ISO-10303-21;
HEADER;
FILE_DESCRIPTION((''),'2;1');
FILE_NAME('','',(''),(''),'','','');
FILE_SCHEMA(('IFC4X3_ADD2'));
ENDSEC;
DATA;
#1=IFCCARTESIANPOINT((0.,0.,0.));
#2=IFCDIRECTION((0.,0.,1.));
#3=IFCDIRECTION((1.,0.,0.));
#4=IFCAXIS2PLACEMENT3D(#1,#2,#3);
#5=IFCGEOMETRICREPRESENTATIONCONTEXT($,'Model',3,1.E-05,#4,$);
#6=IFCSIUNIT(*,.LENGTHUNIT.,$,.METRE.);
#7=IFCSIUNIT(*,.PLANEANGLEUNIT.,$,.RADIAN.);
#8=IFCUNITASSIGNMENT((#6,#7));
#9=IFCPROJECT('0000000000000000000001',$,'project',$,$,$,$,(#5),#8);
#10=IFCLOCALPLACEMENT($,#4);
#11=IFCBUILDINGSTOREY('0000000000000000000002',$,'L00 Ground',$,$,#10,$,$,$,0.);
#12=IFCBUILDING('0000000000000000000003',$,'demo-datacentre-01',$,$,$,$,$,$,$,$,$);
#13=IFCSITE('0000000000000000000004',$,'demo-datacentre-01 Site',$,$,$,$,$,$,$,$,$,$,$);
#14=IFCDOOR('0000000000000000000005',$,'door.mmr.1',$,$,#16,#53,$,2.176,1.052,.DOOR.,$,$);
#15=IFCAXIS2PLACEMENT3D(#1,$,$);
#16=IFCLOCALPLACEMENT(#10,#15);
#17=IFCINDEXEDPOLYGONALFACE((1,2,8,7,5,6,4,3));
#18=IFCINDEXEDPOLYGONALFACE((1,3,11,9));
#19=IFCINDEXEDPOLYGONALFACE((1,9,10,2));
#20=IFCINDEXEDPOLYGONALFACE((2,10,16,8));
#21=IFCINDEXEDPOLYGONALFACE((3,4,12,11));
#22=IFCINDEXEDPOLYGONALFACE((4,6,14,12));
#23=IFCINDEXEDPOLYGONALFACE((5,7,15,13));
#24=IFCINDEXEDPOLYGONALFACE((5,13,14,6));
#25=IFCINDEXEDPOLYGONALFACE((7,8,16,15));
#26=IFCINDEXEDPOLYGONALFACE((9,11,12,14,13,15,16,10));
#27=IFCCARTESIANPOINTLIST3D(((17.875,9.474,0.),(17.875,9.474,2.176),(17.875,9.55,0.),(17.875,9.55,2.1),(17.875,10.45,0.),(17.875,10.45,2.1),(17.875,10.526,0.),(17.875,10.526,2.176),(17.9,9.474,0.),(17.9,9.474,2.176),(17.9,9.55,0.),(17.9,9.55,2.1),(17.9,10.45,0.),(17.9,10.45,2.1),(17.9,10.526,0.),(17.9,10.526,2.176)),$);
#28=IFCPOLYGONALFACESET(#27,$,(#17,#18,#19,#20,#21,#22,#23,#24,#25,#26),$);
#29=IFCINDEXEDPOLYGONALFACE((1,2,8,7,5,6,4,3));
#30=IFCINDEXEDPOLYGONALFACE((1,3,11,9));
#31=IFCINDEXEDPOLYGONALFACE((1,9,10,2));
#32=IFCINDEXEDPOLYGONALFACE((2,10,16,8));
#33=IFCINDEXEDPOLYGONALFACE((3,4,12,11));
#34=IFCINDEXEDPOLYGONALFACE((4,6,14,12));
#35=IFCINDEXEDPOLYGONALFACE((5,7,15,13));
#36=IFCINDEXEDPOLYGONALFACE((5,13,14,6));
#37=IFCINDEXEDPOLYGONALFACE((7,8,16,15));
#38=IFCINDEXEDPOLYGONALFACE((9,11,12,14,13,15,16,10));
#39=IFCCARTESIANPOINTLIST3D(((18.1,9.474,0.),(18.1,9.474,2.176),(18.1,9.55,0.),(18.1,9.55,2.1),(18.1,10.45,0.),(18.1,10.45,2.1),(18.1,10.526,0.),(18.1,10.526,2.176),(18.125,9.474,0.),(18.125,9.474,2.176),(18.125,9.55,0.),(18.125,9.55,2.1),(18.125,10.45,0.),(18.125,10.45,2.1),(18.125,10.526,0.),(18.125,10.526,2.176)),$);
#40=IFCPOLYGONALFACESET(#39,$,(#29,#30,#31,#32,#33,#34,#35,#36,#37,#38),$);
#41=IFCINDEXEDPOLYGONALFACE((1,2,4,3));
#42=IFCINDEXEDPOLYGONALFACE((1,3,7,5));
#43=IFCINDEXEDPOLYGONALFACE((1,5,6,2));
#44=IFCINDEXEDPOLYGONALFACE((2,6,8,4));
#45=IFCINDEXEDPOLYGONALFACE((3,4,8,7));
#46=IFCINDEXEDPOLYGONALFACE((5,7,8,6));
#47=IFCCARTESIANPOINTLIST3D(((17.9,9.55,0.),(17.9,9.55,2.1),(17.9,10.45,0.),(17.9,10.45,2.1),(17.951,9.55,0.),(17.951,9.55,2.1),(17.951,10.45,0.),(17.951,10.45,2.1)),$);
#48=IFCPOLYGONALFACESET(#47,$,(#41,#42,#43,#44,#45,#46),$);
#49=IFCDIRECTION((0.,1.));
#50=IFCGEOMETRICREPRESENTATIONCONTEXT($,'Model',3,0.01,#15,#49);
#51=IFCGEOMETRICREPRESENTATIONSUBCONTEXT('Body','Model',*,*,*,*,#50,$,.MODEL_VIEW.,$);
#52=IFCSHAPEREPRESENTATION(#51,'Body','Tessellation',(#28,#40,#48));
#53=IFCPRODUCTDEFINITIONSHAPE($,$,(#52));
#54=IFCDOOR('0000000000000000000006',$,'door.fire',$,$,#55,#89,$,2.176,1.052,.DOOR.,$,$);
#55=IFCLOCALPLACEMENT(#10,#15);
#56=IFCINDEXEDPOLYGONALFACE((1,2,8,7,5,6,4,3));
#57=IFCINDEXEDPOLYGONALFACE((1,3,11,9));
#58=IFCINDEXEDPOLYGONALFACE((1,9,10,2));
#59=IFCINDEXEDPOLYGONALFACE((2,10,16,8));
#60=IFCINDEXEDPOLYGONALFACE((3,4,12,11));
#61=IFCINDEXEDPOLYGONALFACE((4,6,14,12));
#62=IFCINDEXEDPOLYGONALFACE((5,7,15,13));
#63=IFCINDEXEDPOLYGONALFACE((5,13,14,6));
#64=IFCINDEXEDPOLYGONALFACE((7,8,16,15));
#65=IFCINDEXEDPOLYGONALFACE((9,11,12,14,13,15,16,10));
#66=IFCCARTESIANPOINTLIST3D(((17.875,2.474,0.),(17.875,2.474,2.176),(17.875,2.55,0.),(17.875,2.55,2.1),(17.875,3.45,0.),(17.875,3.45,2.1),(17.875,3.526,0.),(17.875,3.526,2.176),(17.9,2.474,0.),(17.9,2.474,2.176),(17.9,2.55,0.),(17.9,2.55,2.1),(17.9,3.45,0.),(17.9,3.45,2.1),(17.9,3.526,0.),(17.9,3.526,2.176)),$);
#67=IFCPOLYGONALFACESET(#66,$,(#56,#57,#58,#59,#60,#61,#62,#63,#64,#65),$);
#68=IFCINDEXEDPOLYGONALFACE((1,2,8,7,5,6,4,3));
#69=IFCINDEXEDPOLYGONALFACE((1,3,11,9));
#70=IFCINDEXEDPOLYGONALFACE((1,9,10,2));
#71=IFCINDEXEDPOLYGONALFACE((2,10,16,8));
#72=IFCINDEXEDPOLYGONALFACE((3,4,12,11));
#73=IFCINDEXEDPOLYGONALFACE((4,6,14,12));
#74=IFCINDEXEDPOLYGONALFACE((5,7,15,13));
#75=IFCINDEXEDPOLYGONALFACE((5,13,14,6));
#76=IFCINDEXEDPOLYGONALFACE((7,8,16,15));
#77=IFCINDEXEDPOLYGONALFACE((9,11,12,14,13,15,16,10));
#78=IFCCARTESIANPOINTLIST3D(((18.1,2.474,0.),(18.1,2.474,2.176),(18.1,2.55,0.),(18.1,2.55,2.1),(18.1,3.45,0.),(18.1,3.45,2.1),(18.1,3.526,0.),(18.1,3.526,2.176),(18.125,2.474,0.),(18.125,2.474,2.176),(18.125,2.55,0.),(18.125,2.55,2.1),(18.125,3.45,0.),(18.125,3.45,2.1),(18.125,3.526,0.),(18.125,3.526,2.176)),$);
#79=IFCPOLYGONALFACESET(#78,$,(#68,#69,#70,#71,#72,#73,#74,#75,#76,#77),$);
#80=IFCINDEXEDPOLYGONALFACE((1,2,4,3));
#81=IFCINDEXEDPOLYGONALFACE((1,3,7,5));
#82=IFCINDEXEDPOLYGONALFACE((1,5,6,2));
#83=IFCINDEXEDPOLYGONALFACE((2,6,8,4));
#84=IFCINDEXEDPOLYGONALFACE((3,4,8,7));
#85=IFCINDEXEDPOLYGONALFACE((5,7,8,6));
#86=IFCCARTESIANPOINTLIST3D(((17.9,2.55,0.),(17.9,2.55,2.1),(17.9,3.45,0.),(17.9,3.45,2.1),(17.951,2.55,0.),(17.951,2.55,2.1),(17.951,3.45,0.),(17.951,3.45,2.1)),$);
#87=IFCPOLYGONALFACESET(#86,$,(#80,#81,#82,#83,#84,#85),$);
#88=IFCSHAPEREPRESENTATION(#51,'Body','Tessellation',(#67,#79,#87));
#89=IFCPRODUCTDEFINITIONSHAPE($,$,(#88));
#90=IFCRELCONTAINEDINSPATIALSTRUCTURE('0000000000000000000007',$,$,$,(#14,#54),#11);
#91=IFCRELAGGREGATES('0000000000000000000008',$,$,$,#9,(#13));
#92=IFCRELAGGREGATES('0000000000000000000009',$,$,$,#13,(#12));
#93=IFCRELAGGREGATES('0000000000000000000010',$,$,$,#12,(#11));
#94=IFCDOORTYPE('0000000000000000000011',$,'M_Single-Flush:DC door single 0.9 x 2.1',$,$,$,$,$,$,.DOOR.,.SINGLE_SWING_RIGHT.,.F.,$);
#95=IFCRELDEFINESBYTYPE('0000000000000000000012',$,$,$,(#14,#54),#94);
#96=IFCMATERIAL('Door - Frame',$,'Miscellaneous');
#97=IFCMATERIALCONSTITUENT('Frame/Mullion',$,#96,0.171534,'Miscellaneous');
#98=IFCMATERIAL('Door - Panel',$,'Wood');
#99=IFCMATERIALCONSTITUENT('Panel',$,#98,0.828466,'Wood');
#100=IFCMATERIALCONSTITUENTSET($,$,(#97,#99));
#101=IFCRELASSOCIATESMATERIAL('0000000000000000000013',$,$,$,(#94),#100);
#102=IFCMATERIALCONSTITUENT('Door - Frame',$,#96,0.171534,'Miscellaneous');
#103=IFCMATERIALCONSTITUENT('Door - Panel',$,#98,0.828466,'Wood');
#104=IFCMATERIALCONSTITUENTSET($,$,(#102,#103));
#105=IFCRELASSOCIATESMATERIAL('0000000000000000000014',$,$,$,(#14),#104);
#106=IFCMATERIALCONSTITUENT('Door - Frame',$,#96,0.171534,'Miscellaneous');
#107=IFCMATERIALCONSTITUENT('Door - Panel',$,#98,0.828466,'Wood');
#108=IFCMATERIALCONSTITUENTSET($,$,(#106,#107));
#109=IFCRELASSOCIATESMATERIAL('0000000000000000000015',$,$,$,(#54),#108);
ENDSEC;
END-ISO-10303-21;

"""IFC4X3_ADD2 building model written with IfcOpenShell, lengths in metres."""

from ifc_helpers import new_model, si_unit, direction, frame, frame_2d, origin, origin_with_axes, place, context, subcontext, project, spatial, polyline, rectangle, outline, extrude, source, transform, mapped, material, constituent, constituent_set, type_object, type_shapes, element, save


model = new_model("IFC4X3_ADD2")

# Units and contexts
model_context_1 = context("Model", 3, precision=0.01, world=origin(), true_north=direction((0.0, 1.0)))
model_context_2 = context("Model", 3, precision=1e-05, world=origin_with_axes())
body_context = subcontext(model_context_1, "Body", "Model", "MODEL_VIEW")
ifc_project = project(units=[si_unit("LENGTHUNIT", "METRE"), si_unit("PLANEANGLEUNIT", "RADIAN")], contexts=[model_context_2])

# Site, building, storey
site = spatial("IfcSite", under=ifc_project, Name="demo-datacentre-01 Site")
building = spatial("IfcBuilding", under=site, Name="demo-datacentre-01")
storey_placement = place(None, origin_with_axes())
storey = spatial("IfcBuildingStorey", under=building, at=storey_placement, Name="L00 Ground", Elevation=0.0)

# Shared definitions
placement_1 = place(None, origin())
placement_2 = place(placement_1, origin())
placement_3 = place(placement_2, origin())

# Doors
ifc_material_1 = material(Name="Door - Frame", Category="Miscellaneous")
ifc_material_2 = material(Name="Door - Panel", Category="Wood")
ifc_constituent_1 = constituent(ifc_material_1, Name="Frame/Mullion", Category="Miscellaneous", fraction=0.171534)
ifc_constituent_2 = constituent(ifc_material_2, Name="Panel", Category="Wood", fraction=0.828466)
ifc_constituent_set_1 = constituent_set(constituents=[ifc_constituent_1, ifc_constituent_2])
door_type_1 = type_object("IfcDoorType", Name="M_Single-Flush:DC door single 0.9 x 2.1", OperationType="SINGLE_SWING_RIGHT", ParameterTakesPrecedence=False, PredefinedType="DOOR", material=ifc_constituent_set_1)
shared_shape_1 = source(origin(), body_context, "Body", "SweptSolid", [
    extrude(outline(polyline([(-0.526, -1.107), (0.526, -1.107), (0.526, 1.069), (0.45, 1.069), (0.45, -1.031), (-0.45, -1.031), (-0.45, 1.069), (-0.526, 1.069), (-0.526, -1.107)])), frame((0.45, 0.2, 1.069), z_axis=(0.0, 1.0, 0.0), x_axis=(1.0, 0.0, 0.0)), (0.0, 0.0, 1.0), 0.025),
    extrude(outline(polyline([(-1.107, -0.526), (1.069, -0.526), (1.069, -0.45), (-1.031, -0.45), (-1.031, 0.45), (1.069, 0.45), (1.069, 0.526), (-1.107, 0.526), (-1.107, -0.526)])), frame((0.45, -0.025, 1.069), z_axis=(0.0, 1.0, 0.0), x_axis=(0.0, 0.0, -1.0)), (0.0, 0.0, 1.0), 0.025),
    extrude(rectangle(XDim=0.051, YDim=0.9, at=frame_2d((0.0, 0.0), x_axis=(1.0, 0.0))), frame((0.45, 0.1745, 0.0), z_axis=(0.0, 0.0, 1.0), x_axis=(0.0, 1.0, 0.0)), (0.0, 0.0, 1.0), 2.1),
])
type_shapes(door_type_1, [shared_shape_1])
ifc_constituent_3 = constituent(ifc_material_1, Name="Door - Frame", Category="Miscellaneous", fraction=0.171534)
ifc_constituent_4 = constituent(ifc_material_2, Name="Door - Panel", Category="Wood", fraction=0.828466)
ifc_constituent_set_2 = constituent_set(constituents=[ifc_constituent_3, ifc_constituent_4])
door_1_placement = place(placement_3, frame((18.1, 9.55, 0.0), z_axis=(0.0, 0.0, 1.0), x_axis=(0.0, 1.0, 0.0)))
element("IfcDoor", 1, at=door_1_placement, inside=storey, type_object=door_type_1, material=ifc_constituent_set_2, Name="door.mmr.1", OverallHeight=2.176, OverallWidth=1.052, PredefinedType="DOOR", context=body_context, shape_type="MappedRepresentation", body=[
    mapped(shared_shape_1, transform((0.0, 0.0, 0.0), scale=1.0)),
])
ifc_constituent_5 = constituent(ifc_material_1, Name="Door - Frame", Category="Miscellaneous", fraction=0.171534)
ifc_constituent_6 = constituent(ifc_material_2, Name="Door - Panel", Category="Wood", fraction=0.828466)
ifc_constituent_set_3 = constituent_set(constituents=[ifc_constituent_5, ifc_constituent_6])
door_2_placement = place(placement_3, frame((18.1, 2.55, 0.0), z_axis=(0.0, 0.0, 1.0), x_axis=(0.0, 1.0, 0.0)))
element("IfcDoor", 2, at=door_2_placement, inside=storey, type_object=door_type_1, material=ifc_constituent_set_3, Name="door.fire", OverallHeight=2.176, OverallWidth=1.052, PredefinedType="DOOR", context=body_context, shape_type="MappedRepresentation", body=[
    mapped(shared_shape_1, transform((0.0, 0.0, 0.0), scale=1.0)),
])

save(model, "model.ifc")
